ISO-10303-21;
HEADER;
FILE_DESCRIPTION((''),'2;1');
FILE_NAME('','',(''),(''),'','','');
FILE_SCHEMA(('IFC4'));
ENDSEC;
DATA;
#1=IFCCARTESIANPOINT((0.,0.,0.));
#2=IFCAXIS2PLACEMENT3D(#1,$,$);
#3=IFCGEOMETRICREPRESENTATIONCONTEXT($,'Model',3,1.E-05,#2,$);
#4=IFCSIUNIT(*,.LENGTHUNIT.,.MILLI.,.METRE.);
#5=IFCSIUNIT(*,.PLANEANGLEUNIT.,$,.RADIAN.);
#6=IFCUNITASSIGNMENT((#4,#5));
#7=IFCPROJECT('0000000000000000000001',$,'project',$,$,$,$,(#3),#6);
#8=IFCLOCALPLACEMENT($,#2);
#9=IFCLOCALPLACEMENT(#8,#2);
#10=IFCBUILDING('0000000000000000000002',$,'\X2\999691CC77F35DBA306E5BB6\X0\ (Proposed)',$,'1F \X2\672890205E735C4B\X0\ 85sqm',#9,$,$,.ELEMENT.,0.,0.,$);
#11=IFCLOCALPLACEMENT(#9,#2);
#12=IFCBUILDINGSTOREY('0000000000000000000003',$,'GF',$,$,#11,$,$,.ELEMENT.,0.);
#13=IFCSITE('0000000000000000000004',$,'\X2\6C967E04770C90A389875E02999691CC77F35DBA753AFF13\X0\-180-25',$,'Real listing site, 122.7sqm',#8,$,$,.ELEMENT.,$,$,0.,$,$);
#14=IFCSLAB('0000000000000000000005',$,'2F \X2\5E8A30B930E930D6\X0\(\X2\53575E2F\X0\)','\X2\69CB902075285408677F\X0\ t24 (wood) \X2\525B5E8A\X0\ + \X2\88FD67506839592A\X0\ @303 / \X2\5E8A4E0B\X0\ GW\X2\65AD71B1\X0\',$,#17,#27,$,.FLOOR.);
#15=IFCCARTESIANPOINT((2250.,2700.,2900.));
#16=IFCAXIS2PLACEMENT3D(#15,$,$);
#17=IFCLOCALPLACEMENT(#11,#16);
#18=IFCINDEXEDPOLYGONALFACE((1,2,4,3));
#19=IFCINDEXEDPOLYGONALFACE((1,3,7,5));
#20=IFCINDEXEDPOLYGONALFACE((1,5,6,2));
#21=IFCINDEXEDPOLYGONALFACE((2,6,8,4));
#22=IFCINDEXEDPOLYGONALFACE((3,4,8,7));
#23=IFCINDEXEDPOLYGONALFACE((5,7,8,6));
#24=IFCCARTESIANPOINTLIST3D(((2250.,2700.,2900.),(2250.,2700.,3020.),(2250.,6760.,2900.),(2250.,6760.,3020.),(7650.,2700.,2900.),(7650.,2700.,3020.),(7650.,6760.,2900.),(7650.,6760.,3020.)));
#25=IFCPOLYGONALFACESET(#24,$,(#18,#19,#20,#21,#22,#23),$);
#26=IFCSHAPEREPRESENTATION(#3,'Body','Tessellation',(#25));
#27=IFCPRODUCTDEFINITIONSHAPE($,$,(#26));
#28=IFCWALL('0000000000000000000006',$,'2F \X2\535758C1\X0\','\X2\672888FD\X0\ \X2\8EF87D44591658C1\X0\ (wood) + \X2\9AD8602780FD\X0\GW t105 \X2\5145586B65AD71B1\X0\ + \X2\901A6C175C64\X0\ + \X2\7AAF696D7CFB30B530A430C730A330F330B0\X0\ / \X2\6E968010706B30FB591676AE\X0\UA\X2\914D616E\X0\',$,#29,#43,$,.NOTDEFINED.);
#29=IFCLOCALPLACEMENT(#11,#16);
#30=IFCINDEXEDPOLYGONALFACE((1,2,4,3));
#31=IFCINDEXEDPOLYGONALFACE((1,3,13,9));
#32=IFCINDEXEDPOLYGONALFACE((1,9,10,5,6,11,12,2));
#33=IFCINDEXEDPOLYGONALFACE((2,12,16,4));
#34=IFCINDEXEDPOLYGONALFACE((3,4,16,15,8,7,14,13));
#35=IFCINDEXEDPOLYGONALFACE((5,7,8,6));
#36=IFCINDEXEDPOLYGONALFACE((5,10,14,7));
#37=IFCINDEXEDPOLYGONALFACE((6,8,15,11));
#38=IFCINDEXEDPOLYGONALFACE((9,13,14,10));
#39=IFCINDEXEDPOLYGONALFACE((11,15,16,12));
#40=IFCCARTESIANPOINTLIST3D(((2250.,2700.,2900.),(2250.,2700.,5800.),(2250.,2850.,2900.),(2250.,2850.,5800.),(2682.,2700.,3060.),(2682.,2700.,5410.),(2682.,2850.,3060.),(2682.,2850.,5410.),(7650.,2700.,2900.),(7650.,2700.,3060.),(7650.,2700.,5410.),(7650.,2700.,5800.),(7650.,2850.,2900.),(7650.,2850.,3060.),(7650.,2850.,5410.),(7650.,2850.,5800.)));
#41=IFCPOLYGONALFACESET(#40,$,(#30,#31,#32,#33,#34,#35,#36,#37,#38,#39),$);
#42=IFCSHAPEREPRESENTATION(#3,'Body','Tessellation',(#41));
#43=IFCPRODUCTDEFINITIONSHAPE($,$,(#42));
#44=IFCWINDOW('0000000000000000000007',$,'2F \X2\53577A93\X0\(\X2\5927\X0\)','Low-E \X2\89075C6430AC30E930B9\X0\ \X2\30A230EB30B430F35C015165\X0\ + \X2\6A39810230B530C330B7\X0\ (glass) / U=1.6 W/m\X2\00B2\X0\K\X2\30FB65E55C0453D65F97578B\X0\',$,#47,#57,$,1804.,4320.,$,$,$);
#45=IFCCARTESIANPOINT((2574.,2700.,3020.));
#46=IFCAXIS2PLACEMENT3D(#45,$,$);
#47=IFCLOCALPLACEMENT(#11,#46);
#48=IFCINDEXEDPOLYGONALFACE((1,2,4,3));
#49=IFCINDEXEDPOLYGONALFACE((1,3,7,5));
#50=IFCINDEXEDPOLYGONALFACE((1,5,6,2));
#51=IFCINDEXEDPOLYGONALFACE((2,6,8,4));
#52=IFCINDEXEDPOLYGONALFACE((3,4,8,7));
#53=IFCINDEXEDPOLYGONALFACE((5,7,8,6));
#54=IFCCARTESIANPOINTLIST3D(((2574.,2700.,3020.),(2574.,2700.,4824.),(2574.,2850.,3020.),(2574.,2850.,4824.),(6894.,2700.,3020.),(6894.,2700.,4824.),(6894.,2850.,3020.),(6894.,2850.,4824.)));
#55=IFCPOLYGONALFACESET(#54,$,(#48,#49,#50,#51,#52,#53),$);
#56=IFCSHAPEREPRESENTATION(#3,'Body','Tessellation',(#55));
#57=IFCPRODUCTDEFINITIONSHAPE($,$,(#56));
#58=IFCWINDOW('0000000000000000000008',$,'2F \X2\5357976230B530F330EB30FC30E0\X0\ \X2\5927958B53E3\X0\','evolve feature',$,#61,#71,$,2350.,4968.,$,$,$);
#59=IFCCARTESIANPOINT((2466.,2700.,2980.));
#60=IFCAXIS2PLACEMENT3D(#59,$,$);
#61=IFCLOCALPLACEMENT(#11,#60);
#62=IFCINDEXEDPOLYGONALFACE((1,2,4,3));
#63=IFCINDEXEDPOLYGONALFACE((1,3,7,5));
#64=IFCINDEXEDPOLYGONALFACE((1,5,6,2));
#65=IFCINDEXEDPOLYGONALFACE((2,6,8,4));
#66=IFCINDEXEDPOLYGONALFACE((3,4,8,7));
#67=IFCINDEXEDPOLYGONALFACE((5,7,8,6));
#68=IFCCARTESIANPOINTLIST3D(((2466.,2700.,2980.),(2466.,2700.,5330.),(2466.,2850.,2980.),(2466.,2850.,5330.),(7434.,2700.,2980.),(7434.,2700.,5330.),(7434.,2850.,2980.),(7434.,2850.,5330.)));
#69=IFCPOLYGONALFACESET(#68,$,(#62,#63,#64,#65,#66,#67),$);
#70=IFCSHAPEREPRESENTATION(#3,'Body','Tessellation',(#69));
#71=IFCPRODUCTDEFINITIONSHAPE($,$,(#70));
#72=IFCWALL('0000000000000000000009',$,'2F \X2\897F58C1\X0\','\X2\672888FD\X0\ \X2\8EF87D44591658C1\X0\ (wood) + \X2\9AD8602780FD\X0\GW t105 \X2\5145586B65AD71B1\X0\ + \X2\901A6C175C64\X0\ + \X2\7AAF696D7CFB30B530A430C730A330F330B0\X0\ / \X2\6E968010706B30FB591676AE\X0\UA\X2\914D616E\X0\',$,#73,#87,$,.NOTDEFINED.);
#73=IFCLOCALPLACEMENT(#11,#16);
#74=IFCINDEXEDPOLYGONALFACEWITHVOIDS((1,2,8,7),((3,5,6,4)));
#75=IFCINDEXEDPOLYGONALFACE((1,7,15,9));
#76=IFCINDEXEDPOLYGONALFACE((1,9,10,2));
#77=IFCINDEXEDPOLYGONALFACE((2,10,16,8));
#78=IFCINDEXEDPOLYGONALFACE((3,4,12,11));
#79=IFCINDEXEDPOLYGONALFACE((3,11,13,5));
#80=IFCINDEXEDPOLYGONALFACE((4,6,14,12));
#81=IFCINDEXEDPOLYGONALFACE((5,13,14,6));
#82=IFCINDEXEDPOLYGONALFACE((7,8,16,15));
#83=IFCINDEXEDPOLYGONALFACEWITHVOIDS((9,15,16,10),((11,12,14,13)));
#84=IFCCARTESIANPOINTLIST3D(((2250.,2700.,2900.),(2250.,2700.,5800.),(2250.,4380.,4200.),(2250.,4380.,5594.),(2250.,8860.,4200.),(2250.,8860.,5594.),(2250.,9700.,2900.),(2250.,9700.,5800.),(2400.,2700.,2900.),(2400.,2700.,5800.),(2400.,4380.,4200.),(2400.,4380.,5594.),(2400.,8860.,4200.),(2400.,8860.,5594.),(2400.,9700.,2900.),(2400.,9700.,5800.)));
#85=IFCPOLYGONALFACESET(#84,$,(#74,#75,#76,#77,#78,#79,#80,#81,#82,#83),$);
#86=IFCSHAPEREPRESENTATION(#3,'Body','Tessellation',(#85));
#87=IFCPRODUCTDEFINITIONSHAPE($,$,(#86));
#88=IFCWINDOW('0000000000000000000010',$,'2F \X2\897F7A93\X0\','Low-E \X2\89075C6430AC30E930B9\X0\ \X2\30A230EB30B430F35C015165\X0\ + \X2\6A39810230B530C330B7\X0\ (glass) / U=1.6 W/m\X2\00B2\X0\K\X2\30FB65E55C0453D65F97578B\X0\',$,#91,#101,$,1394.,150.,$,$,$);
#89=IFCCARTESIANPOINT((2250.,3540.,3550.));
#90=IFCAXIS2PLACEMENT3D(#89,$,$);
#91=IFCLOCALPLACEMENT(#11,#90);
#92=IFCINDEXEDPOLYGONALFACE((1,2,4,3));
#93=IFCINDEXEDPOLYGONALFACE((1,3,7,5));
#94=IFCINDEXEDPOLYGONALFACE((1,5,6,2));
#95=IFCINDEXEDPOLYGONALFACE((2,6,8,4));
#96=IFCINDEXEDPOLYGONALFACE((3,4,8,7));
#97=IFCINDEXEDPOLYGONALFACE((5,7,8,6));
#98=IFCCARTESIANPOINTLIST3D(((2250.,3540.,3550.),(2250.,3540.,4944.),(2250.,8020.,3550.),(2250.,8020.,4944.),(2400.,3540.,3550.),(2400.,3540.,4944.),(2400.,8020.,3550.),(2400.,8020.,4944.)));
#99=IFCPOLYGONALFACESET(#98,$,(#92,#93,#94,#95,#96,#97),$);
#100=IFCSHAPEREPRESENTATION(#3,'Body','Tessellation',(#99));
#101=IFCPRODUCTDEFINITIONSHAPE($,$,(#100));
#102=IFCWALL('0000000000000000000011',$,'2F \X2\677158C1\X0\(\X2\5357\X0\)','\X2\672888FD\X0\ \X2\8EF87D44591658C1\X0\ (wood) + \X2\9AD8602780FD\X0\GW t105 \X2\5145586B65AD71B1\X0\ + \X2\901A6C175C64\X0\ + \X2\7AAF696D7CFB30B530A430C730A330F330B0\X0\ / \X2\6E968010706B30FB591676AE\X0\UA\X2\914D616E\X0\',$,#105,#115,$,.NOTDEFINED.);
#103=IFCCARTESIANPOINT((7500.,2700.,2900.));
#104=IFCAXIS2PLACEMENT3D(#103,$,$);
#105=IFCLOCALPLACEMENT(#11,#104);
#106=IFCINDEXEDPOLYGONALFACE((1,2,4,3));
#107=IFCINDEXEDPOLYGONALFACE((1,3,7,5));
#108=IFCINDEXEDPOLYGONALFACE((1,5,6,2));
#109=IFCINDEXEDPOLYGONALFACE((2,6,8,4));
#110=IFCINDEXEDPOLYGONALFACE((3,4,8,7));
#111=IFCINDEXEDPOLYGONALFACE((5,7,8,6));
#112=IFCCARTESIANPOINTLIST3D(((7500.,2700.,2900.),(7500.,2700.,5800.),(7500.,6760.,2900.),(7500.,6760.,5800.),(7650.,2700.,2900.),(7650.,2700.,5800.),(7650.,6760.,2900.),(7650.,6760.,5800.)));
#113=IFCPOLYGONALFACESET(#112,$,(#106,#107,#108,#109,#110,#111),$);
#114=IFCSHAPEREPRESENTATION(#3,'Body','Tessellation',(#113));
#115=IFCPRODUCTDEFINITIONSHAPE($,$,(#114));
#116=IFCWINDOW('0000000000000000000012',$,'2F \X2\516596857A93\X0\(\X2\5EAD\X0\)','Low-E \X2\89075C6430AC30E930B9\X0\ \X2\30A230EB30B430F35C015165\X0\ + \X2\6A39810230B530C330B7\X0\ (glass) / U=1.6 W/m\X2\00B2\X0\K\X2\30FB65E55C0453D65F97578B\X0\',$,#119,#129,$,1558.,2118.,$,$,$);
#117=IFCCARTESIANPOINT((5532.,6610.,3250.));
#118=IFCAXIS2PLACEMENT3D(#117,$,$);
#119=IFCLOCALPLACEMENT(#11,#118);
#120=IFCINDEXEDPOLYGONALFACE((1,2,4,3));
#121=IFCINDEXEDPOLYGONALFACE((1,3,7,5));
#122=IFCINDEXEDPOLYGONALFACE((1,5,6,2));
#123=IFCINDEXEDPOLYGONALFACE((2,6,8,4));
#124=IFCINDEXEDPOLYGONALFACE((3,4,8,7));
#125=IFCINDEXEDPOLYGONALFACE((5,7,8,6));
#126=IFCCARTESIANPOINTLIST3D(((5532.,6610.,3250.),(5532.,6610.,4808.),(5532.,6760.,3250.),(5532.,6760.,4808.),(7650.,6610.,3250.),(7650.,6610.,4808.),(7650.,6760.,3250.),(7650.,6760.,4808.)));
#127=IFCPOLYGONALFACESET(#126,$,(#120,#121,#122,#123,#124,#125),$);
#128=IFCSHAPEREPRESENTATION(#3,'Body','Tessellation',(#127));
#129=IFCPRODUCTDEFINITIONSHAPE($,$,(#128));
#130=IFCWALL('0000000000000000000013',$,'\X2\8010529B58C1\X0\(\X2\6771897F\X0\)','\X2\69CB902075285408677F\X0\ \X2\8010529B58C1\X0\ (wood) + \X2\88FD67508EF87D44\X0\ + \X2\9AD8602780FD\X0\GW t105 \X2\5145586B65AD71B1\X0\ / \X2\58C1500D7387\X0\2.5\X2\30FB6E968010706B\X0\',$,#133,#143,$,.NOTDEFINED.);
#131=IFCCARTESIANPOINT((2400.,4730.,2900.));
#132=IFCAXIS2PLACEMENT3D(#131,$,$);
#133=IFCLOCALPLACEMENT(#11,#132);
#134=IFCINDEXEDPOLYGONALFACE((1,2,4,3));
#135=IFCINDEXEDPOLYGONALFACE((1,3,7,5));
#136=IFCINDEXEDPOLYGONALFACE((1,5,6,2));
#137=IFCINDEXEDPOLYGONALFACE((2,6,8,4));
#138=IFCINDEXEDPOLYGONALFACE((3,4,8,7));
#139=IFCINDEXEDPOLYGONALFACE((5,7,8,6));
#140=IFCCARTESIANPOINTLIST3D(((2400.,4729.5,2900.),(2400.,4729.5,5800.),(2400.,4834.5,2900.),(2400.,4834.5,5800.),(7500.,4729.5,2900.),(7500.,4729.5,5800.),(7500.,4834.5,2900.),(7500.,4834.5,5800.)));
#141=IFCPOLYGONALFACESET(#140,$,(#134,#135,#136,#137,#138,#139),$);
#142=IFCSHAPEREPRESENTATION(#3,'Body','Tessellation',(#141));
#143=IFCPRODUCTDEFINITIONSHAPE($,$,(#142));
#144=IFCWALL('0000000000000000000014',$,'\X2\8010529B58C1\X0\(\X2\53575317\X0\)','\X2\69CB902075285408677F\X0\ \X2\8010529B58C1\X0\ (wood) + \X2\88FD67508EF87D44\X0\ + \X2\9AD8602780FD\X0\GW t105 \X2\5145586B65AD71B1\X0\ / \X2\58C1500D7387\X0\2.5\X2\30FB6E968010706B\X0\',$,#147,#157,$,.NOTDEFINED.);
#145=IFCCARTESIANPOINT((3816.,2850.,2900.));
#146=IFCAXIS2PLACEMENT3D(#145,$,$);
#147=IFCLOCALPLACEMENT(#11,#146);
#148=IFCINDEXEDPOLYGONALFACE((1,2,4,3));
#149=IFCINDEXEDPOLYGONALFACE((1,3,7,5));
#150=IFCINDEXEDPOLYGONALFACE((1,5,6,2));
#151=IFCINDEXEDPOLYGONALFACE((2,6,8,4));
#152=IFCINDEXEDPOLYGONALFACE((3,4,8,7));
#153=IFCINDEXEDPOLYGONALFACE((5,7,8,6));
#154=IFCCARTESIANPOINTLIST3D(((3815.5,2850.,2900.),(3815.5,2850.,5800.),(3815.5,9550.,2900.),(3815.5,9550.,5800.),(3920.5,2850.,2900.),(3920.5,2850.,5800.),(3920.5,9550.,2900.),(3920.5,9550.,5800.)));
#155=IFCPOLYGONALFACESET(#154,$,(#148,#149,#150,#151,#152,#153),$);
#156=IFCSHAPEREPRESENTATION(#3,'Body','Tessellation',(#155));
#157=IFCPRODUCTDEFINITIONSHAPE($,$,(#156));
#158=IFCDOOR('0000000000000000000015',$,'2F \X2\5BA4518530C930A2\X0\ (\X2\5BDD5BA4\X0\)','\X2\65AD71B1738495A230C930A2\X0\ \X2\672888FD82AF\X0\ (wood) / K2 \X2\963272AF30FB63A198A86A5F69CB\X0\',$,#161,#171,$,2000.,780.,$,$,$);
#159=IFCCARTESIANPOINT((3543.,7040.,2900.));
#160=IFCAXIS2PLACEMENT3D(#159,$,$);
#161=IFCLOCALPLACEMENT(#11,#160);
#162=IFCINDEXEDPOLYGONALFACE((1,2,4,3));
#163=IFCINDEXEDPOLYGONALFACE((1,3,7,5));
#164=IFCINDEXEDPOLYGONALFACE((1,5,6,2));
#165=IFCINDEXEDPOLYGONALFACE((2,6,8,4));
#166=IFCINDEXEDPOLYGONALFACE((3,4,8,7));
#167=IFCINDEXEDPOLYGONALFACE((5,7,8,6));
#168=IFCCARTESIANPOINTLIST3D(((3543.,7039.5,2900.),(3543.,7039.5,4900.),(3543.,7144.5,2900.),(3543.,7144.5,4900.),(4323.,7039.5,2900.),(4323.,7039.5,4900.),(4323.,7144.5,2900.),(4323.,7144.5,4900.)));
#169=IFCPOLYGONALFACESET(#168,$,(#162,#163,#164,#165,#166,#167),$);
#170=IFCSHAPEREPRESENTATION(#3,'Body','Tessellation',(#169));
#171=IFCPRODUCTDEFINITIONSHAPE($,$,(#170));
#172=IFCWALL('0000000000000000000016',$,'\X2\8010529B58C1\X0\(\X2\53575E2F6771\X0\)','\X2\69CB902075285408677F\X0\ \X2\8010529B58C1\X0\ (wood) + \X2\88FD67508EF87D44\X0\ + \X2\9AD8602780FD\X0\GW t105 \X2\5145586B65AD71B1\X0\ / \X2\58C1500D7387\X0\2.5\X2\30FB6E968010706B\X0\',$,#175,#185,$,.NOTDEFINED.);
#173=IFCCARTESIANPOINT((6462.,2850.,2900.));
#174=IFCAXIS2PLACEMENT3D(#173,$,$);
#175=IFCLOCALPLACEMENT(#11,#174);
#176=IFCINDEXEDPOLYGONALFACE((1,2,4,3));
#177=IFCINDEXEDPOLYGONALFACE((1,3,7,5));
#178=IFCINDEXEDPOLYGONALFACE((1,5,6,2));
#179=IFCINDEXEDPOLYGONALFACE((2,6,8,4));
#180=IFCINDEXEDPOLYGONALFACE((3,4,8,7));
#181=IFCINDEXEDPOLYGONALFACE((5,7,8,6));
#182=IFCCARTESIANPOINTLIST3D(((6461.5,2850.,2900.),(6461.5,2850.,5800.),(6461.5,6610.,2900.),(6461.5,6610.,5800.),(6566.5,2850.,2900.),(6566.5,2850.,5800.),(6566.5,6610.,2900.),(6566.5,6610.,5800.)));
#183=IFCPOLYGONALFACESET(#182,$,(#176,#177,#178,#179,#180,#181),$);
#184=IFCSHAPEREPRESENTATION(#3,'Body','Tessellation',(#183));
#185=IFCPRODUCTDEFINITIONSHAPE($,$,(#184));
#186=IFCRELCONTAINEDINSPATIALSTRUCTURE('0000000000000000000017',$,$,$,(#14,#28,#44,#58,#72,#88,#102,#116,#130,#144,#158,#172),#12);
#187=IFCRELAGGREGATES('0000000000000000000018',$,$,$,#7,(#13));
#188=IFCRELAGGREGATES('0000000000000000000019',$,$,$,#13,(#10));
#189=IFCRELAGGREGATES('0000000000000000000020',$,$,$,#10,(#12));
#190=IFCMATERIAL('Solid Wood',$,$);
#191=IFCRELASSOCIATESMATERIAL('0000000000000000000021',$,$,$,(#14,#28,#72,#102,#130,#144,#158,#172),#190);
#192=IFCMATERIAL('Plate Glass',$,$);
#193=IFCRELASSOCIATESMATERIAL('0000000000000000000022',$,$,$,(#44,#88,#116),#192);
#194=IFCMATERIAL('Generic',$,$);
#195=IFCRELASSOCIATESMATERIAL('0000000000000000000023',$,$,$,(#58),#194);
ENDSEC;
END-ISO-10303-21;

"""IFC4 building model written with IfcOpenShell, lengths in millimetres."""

from ifc_helpers import new_model, si_unit, frame, frame_2d, origin, place, context, project, spatial, rectangle, extrude, material, element, fill, save


model = new_model("IFC4")

# Units and contexts
model_context = context("Model", 3, precision=1e-05, world=origin())
ifc_project = project(units=[si_unit("LENGTHUNIT", "METRE", prefix="MILLI"), si_unit("PLANEANGLEUNIT", "RADIAN")], contexts=[model_context])

# Site, building, storey
site_placement = place(None, origin())
site = spatial("IfcSite", under=ifc_project, at=site_placement, Name="沖縄県那覇市首里石嶺町３-180-25", ObjectType="Real listing site, 122.7sqm", CompositionType="ELEMENT", RefElevation=0.0)
building_placement = place(site_placement, origin())
building = spatial("IfcBuilding", under=site, at=building_placement, Name="首里石嶺の家 (Proposed)", ObjectType="1F 木造平屋 85sqm", CompositionType="ELEMENT", ElevationOfRefHeight=0.0, ElevationOfTerrain=0.0)
storey_placement = place(building_placement, origin())
storey = spatial("IfcBuildingStorey", under=building, at=storey_placement, Name="GF", CompositionType="ELEMENT", Elevation=0.0)

# Slab
ifc_material_1 = material(Name="Solid Wood")
slab_placement = place(storey_placement, frame((2250.0, 2700.0, 2900.0)))
element("IfcSlab", 1, at=slab_placement, inside=storey, material=ifc_material_1, Name="2F 床スラブ(南帯)", Description="構造用合板 t24 (wood) 剛床 + 製材根太 @303 / 床下 GW断熱", PredefinedType="FLOOR", context=model_context, shape_type="SweptSolid", body=[
    extrude(rectangle(XDim=5400.0, YDim=4060.0, at=frame_2d((2700.0, 2030.0))), frame((2250.0, 2700.0, 2900.0)), (0.0, 0.0, 1.0), 120.0),
])

# Wall, openings, windows
wall_1_placement = place(storey_placement, frame((2250.0, 2700.0, 2900.0)))
wall_1 = element("IfcWall", 2, at=wall_1_placement, inside=storey, material=ifc_material_1, Name="2F 南壁", Description="木製 軸組外壁 (wood) + 高性能GW t105 充填断熱 + 通気層 + 窯業系サイディング / 準耐火・外皮UA配慮", PredefinedType="NOTDEFINED", context=model_context, shape_type="SweptSolid", body=[
    extrude(rectangle(XDim=5400.0, YDim=150.0, at=frame_2d((2700.0, 75.0))), frame((2250.0, 2700.0, 2900.0)), (0.0, 0.0, 1.0), 2900.0),
])
opening_1_placement = place(storey_placement, frame((2574.0, 2700.0, 3020.0)))
opening_1 = element("IfcOpeningElement", 3, at=opening_1_placement, cuts=wall_1, PredefinedType="NOTDEFINED", context=model_context, shape_type="SweptSolid", body=[
    extrude(rectangle(XDim=4320.0, YDim=150.0, at=frame_2d((2160.0, 75.0))), frame((2574.0, 2700.0, 3020.0)), (0.0, 0.0, 1.0), 1804.0),
])
opening_2_placement = place(storey_placement, frame((2466.0, 2700.0, 2980.0)))
opening_2 = element("IfcOpeningElement", 4, at=opening_2_placement, cuts=wall_1, PredefinedType="NOTDEFINED", context=model_context, shape_type="SweptSolid", body=[
    extrude(rectangle(XDim=4968.0, YDim=150.0, at=frame_2d((2484.0, 75.0))), frame((2466.0, 2700.0, 2980.0)), (0.0, 0.0, 1.0), 2350.0),
])
ifc_material_2 = material(Name="Plate Glass")
window_1_placement = place(storey_placement, frame((2574.0, 2700.0, 3020.0)))
window_1 = element("IfcWindow", 5, at=window_1_placement, inside=storey, material=ifc_material_2, Name="2F 南窓(大)", Description="Low-E 複層ガラス アルゴン封入 + 樹脂サッシ (glass) / U=1.6 W/m²K・日射取得型", OverallHeight=1804.0, OverallWidth=4320.0, context=model_context, shape_type="SweptSolid", body=[
    extrude(rectangle(XDim=4320.0, YDim=150.0, at=frame_2d((2160.0, 75.0))), frame((2574.0, 2700.0, 3020.0)), (0.0, 0.0, 1.0), 1804.0),
])
fill(opening_1, window_1)
ifc_material_3 = material(Name="Generic")
window_2_placement = place(storey_placement, frame((2466.0, 2700.0, 2980.0)))
window_2 = element("IfcWindow", 6, at=window_2_placement, inside=storey, material=ifc_material_3, Name="2F 南面サンルーム 大開口", Description="evolve feature", OverallHeight=2350.0, OverallWidth=4968.0, context=model_context, shape_type="SweptSolid", body=[
    extrude(rectangle(XDim=4968.0, YDim=150.0, at=frame_2d((2484.0, 75.0))), frame((2466.0, 2700.0, 2980.0)), (0.0, 0.0, 1.0), 2350.0),
])
fill(opening_2, window_2)

# Walls, openings, windows
wall_2_placement = place(storey_placement, frame((2250.0, 2700.0, 2900.0)))
wall_2 = element("IfcWall", 7, at=wall_2_placement, inside=storey, material=ifc_material_1, Name="2F 西壁", Description="木製 軸組外壁 (wood) + 高性能GW t105 充填断熱 + 通気層 + 窯業系サイディング / 準耐火・外皮UA配慮", PredefinedType="NOTDEFINED", context=model_context, shape_type="SweptSolid", body=[
    extrude(rectangle(XDim=150.0, YDim=7000.0, at=frame_2d((75.0, 3500.0))), frame((2250.0, 2700.0, 2900.0)), (0.0, 0.0, 1.0), 2900.0),
])
opening_3_placement = place(storey_placement, frame((2250.0, 3540.0, 3550.0)))
opening_3 = element("IfcOpeningElement", 8, at=opening_3_placement, cuts=wall_2, PredefinedType="NOTDEFINED", context=model_context, shape_type="SweptSolid", body=[
    extrude(rectangle(XDim=150.0, YDim=4480.0, at=frame_2d((75.0, 2240.0))), frame((2250.0, 3540.0, 3550.0)), (0.0, 0.0, 1.0), 1394.0),
])
window_3_placement = place(storey_placement, frame((2250.0, 3540.0, 3550.0)))
window_3 = element("IfcWindow", 9, at=window_3_placement, inside=storey, material=ifc_material_2, Name="2F 西窓", Description="Low-E 複層ガラス アルゴン封入 + 樹脂サッシ (glass) / U=1.6 W/m²K・日射取得型", OverallHeight=1394.0, OverallWidth=150.0, context=model_context, shape_type="SweptSolid", body=[
    extrude(rectangle(XDim=150.0, YDim=4480.0, at=frame_2d((75.0, 2240.0))), frame((2250.0, 3540.0, 3550.0)), (0.0, 0.0, 1.0), 1394.0),
])
fill(opening_3, window_3)
wall_3_placement = place(storey_placement, frame((7500.0, 2700.0, 2900.0)))
wall_3 = element("IfcWall", 10, at=wall_3_placement, inside=storey, material=ifc_material_1, Name="2F 東壁(南)", Description="木製 軸組外壁 (wood) + 高性能GW t105 充填断熱 + 通気層 + 窯業系サイディング / 準耐火・外皮UA配慮", PredefinedType="NOTDEFINED", context=model_context, shape_type="SweptSolid", body=[
    extrude(rectangle(XDim=150.0, YDim=4060.0, at=frame_2d((75.0, 2030.0))), frame((7500.0, 2700.0, 2900.0)), (0.0, 0.0, 1.0), 2900.0),
])
opening_4_placement = place(storey_placement, frame((5532.0, 6610.0, 3250.0)))
opening_4 = element("IfcOpeningElement", 11, at=opening_4_placement, cuts=wall_3, PredefinedType="NOTDEFINED", context=model_context, shape_type="SweptSolid", body=[
    extrude(rectangle(XDim=2118.0, YDim=150.0, at=frame_2d((1059.0, 75.0))), frame((5532.0, 6610.0, 3250.0)), (0.0, 0.0, 1.0), 1558.0),
])
window_4_placement = place(storey_placement, frame((5532.0, 6610.0, 3250.0)))
window_4 = element("IfcWindow", 12, at=window_4_placement, inside=storey, material=ifc_material_2, Name="2F 入隅窓(庭)", Description="Low-E 複層ガラス アルゴン封入 + 樹脂サッシ (glass) / U=1.6 W/m²K・日射取得型", OverallHeight=1558.0, OverallWidth=2118.0, context=model_context, shape_type="SweptSolid", body=[
    extrude(rectangle(XDim=2118.0, YDim=150.0, at=frame_2d((1059.0, 75.0))), frame((5532.0, 6610.0, 3250.0)), (0.0, 0.0, 1.0), 1558.0),
])
fill(opening_4, window_4)

# Wall
wall_4_placement = place(storey_placement, frame((2400.0, 4730.0, 2900.0)))
element("IfcWall", 13, at=wall_4_placement, inside=storey, material=ifc_material_1, Name="耐力壁(東西)", Description="構造用合板 耐力壁 (wood) + 製材軸組 + 高性能GW t105 充填断熱 / 壁倍率2.5・準耐火", PredefinedType="NOTDEFINED", context=model_context, shape_type="SweptSolid", body=[
    extrude(rectangle(XDim=5100.0, YDim=105.0, at=frame_2d((2550.0, 52.0))), frame((2400.0, 4730.0, 2900.0)), (0.0, 0.0, 1.0), 2900.0),
])

# Wall, opening, door
wall_5_placement = place(storey_placement, frame((3816.0, 2850.0, 2900.0)))
wall_5 = element("IfcWall", 14, at=wall_5_placement, inside=storey, material=ifc_material_1, Name="耐力壁(南北)", Description="構造用合板 耐力壁 (wood) + 製材軸組 + 高性能GW t105 充填断熱 / 壁倍率2.5・準耐火", PredefinedType="NOTDEFINED", context=model_context, shape_type="SweptSolid", body=[
    extrude(rectangle(XDim=105.0, YDim=6700.0, at=frame_2d((52.0, 3350.0))), frame((3816.0, 2850.0, 2900.0)), (0.0, 0.0, 1.0), 2900.0),
])
opening_5_placement = place(storey_placement, frame((3543.0, 7040.0, 2900.0)))
opening_5 = element("IfcOpeningElement", 15, at=opening_5_placement, cuts=wall_5, PredefinedType="NOTDEFINED", context=model_context, shape_type="SweptSolid", body=[
    extrude(rectangle(XDim=780.0, YDim=105.0, at=frame_2d((390.0, 52.0))), frame((3543.0, 7040.0, 2900.0)), (0.0, 0.0, 1.0), 2000.0),
])
door_placement = place(storey_placement, frame((3543.0, 7040.0, 2900.0)))
door = element("IfcDoor", 16, at=door_placement, inside=storey, material=ifc_material_1, Name="2F 室内ドア (寝室)", Description="断熱玄関ドア 木製芯 (wood) / K2 防犯・採風機構", OverallHeight=2000.0, OverallWidth=780.0, context=model_context, shape_type="SweptSolid", body=[
    extrude(rectangle(XDim=780.0, YDim=105.0, at=frame_2d((390.0, 52.0))), frame((3543.0, 7040.0, 2900.0)), (0.0, 0.0, 1.0), 2000.0),
])
fill(opening_5, door)

# Wall
wall_6_placement = place(storey_placement, frame((6462.0, 2850.0, 2900.0)))
element("IfcWall", 17, at=wall_6_placement, inside=storey, material=ifc_material_1, Name="耐力壁(南帯東)", Description="構造用合板 耐力壁 (wood) + 製材軸組 + 高性能GW t105 充填断熱 / 壁倍率2.5・準耐火", PredefinedType="NOTDEFINED", context=model_context, shape_type="SweptSolid", body=[
    extrude(rectangle(XDim=105.0, YDim=3760.0, at=frame_2d((52.0, 1880.0))), frame((6462.0, 2850.0, 2900.0)), (0.0, 0.0, 1.0), 2900.0),
])

save(model, "model.ifc")
